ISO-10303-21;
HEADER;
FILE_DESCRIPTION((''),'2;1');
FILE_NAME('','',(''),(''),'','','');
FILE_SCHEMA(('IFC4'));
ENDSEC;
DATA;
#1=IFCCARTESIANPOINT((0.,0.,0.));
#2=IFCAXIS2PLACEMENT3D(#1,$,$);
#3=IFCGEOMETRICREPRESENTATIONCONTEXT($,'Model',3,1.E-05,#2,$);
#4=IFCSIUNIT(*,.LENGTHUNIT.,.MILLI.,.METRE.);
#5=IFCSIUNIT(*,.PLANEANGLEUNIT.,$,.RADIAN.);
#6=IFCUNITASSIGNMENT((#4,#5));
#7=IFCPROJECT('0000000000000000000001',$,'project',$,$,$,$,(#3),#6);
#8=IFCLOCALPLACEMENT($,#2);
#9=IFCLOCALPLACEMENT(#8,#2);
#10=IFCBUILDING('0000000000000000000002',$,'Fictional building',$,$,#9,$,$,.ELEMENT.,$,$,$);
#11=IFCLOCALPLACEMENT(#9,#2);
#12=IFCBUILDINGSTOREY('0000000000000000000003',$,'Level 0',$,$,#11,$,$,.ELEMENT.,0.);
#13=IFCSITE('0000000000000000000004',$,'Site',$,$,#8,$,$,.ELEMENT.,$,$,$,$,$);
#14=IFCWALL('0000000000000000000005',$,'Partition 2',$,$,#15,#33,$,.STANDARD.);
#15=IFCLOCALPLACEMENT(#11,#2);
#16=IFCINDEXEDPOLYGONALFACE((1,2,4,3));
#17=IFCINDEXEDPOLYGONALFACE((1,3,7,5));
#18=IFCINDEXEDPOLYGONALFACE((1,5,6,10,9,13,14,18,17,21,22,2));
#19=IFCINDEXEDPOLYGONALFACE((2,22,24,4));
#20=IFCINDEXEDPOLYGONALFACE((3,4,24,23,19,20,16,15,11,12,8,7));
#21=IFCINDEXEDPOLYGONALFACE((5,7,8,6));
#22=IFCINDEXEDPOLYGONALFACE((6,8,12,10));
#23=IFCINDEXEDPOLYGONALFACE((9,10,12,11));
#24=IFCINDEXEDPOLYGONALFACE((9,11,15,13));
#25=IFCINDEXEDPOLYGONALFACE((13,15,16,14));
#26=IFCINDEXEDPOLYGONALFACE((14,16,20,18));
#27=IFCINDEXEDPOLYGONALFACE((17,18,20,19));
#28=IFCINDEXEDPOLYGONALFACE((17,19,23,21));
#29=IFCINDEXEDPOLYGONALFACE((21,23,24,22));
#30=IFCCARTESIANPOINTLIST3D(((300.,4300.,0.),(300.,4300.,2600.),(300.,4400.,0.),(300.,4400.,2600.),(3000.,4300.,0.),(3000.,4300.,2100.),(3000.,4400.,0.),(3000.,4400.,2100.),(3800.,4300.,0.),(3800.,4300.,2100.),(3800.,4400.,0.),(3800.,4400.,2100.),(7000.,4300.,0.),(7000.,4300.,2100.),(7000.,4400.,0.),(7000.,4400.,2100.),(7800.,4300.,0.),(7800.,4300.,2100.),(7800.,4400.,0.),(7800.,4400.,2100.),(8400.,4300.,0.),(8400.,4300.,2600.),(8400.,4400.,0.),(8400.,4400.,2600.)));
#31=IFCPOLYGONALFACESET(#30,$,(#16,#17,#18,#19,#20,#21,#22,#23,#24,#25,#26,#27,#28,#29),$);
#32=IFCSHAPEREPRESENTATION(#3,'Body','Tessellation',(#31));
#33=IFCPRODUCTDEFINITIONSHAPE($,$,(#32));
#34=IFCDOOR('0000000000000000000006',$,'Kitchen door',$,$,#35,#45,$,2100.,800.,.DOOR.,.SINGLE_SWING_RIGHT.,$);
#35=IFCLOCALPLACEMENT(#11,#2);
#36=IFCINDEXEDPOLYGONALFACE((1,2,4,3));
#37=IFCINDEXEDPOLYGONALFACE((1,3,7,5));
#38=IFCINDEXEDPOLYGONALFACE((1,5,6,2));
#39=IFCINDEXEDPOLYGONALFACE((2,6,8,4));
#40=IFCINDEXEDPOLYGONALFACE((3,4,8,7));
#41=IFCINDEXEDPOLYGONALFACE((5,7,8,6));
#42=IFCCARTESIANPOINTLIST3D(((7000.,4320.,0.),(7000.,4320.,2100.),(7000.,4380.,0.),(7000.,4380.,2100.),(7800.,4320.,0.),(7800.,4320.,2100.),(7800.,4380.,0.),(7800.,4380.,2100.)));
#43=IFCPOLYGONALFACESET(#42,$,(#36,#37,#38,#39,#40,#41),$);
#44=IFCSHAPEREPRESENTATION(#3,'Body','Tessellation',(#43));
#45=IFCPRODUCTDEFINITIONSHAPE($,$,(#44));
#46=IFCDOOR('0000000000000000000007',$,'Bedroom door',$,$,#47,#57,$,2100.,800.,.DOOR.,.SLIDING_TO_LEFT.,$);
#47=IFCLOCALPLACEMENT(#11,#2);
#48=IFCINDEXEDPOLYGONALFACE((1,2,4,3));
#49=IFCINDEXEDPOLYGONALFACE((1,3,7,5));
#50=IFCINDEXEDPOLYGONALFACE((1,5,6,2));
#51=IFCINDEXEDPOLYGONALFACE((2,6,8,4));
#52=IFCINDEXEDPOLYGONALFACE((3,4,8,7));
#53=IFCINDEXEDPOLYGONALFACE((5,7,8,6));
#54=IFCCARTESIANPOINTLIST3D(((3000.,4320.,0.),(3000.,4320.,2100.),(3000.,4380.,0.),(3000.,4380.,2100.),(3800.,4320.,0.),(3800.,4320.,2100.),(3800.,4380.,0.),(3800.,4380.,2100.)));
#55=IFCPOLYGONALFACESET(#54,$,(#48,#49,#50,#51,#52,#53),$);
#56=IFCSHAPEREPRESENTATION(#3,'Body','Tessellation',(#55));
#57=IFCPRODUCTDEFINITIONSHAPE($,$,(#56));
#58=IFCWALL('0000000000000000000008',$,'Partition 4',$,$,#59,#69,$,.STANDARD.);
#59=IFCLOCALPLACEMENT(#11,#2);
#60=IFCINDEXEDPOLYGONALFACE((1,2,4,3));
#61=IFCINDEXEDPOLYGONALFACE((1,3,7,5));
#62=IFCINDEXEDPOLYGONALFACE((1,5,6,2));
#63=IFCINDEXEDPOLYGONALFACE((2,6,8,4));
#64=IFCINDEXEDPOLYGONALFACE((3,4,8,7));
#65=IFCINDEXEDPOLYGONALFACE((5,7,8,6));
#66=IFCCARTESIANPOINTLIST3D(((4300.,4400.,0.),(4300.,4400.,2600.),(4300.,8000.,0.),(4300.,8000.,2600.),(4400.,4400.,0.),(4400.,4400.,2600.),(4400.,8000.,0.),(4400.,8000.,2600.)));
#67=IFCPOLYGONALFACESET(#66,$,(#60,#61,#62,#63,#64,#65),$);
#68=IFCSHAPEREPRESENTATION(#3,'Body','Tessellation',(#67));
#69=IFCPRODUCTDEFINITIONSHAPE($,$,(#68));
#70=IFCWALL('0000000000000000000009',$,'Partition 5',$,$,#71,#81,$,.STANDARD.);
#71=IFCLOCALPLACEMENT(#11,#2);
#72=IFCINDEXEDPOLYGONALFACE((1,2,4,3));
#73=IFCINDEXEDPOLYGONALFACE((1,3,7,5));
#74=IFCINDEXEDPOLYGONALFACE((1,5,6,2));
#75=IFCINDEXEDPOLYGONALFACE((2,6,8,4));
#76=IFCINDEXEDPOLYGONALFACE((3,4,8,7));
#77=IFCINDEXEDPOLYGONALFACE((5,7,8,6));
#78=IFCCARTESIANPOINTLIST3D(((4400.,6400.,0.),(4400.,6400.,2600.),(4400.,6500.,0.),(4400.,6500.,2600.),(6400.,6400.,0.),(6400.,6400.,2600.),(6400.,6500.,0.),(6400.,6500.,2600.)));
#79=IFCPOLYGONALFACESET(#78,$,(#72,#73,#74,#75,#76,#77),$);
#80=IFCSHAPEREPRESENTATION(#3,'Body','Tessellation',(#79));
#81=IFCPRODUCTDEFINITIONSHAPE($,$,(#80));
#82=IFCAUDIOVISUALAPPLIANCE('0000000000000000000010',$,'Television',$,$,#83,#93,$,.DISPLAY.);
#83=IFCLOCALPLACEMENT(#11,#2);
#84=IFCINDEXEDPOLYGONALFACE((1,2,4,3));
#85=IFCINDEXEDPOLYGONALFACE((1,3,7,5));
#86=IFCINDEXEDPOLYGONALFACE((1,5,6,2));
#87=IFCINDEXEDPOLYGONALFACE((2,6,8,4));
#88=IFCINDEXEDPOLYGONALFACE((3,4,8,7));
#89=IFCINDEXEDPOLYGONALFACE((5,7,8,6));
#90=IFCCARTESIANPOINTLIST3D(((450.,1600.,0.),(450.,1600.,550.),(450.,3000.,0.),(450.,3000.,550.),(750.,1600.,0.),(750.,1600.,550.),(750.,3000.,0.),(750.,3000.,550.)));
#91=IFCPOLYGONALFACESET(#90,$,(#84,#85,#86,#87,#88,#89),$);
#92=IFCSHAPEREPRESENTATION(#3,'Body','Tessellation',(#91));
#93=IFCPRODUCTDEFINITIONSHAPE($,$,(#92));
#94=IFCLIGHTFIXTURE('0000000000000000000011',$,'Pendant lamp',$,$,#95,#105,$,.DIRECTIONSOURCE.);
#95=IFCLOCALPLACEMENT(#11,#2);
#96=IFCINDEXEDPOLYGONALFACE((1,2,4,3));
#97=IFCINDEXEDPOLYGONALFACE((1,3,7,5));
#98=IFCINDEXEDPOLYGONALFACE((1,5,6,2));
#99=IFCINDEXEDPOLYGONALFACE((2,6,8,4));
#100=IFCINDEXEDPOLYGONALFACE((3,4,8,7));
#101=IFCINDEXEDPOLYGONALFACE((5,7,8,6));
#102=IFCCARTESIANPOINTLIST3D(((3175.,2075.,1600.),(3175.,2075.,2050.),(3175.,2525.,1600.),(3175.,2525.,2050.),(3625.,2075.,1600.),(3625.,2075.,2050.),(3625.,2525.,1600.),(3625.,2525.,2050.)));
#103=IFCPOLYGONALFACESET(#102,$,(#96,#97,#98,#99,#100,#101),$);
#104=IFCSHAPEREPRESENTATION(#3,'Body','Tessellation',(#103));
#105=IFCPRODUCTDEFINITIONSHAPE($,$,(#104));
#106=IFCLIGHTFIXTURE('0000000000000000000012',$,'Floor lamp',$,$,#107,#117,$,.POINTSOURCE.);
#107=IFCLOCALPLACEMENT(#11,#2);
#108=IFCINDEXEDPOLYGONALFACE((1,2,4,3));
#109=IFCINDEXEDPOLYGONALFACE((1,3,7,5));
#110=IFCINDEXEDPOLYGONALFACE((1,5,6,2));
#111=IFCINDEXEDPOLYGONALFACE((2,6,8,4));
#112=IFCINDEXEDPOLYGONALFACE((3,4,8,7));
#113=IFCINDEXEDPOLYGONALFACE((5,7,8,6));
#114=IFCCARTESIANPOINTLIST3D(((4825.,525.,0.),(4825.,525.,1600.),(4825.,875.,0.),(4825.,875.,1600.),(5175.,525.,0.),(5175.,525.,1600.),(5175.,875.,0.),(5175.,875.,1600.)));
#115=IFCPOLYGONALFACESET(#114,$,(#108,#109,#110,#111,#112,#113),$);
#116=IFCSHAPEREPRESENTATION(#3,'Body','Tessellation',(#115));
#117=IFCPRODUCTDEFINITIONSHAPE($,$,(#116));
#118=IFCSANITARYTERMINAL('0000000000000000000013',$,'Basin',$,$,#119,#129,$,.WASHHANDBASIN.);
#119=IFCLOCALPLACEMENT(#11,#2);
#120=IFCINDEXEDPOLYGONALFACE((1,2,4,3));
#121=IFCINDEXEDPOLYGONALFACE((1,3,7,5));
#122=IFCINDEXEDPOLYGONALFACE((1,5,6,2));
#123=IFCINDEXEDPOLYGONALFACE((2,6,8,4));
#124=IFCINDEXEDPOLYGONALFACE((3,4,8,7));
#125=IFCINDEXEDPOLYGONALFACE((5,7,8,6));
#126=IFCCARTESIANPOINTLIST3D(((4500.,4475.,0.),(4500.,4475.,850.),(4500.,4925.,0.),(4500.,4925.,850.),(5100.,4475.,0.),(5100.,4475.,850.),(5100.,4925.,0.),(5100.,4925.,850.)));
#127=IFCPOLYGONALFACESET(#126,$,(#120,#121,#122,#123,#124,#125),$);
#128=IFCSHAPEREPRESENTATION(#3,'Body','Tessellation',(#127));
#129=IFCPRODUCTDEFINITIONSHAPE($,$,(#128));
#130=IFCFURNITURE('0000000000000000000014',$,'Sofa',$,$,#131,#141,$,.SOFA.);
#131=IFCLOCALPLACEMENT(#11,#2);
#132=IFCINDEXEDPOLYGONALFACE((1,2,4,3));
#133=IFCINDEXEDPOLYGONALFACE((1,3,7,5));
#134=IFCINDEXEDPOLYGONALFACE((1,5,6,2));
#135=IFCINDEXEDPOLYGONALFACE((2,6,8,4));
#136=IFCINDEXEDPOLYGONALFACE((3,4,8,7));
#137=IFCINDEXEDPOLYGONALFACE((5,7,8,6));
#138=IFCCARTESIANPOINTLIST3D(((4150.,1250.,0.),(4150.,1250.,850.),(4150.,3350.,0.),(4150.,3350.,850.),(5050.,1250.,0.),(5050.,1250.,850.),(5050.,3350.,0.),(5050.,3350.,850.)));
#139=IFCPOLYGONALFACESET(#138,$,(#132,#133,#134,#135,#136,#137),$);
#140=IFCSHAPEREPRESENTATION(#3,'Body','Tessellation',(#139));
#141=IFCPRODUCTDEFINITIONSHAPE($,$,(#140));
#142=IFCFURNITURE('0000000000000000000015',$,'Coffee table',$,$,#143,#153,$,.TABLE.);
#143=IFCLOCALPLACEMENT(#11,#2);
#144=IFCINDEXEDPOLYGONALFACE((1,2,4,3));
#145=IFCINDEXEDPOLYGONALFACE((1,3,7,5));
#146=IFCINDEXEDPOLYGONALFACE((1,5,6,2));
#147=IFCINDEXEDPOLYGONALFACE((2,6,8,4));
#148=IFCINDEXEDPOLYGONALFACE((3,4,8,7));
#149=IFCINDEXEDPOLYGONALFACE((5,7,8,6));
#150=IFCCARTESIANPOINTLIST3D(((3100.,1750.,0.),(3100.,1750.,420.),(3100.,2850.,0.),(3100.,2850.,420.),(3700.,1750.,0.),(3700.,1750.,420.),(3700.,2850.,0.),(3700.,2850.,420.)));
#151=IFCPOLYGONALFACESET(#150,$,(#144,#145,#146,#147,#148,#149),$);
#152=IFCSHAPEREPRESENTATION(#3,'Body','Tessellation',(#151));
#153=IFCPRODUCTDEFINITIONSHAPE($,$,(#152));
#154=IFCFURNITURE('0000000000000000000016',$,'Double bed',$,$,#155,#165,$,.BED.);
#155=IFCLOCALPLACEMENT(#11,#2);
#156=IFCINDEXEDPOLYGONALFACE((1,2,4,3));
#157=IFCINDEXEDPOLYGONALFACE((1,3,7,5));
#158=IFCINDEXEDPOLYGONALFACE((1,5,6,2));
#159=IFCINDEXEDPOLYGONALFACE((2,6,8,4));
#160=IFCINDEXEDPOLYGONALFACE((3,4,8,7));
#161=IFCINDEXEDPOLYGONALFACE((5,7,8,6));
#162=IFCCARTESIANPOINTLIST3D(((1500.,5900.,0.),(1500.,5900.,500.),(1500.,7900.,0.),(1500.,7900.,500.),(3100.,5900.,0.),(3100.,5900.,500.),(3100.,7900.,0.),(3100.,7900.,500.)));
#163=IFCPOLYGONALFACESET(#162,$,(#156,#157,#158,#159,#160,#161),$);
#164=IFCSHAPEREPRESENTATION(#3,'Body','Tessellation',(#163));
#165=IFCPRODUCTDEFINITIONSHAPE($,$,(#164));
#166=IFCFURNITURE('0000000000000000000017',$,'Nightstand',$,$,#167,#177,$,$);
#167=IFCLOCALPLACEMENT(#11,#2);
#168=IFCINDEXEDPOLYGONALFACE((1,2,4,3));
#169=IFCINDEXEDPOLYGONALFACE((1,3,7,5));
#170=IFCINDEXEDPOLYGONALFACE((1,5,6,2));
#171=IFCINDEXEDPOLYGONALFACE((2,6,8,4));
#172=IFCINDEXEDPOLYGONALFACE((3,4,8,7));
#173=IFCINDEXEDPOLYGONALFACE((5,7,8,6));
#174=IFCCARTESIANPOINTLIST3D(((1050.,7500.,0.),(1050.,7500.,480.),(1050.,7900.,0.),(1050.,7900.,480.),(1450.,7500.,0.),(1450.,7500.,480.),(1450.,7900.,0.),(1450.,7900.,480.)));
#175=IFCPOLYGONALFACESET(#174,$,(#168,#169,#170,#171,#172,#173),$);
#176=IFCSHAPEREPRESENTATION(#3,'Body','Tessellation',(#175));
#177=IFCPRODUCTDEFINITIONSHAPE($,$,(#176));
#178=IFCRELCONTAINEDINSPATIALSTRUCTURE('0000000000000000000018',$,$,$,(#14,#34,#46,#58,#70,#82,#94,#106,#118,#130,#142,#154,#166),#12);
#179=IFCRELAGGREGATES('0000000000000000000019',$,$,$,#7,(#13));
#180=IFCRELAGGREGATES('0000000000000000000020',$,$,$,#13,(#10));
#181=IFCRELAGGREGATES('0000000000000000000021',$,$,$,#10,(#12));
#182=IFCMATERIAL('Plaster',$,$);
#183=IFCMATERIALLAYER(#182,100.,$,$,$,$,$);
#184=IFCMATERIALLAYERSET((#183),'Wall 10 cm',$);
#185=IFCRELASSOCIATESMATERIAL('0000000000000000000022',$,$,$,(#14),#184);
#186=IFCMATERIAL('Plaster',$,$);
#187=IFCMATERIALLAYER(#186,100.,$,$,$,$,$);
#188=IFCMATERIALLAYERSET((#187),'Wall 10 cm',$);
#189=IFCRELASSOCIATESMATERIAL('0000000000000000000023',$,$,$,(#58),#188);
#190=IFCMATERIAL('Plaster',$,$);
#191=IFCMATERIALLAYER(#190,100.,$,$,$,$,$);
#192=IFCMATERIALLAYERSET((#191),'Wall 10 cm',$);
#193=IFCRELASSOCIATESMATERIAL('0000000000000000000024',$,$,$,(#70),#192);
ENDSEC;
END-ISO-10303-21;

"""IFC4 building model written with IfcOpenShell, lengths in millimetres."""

from ifc_helpers import new_model, si_unit, frame, frame_2d, origin, origin_2d, place, context, project, spatial, rectangle, extrude, source, transform, mapped, material, layer, layer_set, layer_usage, element, fill, save


model = new_model("IFC4")

# Units and contexts
model_context = context("Model", 3, precision=1e-05, world=origin())
ifc_project = project(units=[si_unit("LENGTHUNIT", "METRE", prefix="MILLI"), si_unit("PLANEANGLEUNIT", "RADIAN")], contexts=[model_context])

# Site, building, storey
site_placement = place(None, origin())
site = spatial("IfcSite", under=ifc_project, at=site_placement, Name="Site", CompositionType="ELEMENT")
building_placement = place(site_placement, origin())
building = spatial("IfcBuilding", under=site, at=building_placement, Name="Fictional building", CompositionType="ELEMENT")
storey_placement = place(building_placement, origin())
storey = spatial("IfcBuildingStorey", under=building, at=storey_placement, Name="Level 0", CompositionType="ELEMENT", Elevation=0.0)

# Wall, openings, doors
ifc_material_1 = material(Name="Plaster")
ifc_layer_1 = layer(ifc_material_1, 100.0)
ifc_layer_set_1 = layer_set([ifc_layer_1], Name="Wall 10 cm")
ifc_layer_usage_1 = layer_usage(ifc_layer_set_1, "AXIS2", "POSITIVE", -50.0)
wall_1_placement = place(storey_placement, frame((300.0, 4350.0, 0.0)))
wall_1 = element("IfcWall", 1, at=wall_1_placement, inside=storey, material=ifc_layer_usage_1, Name="Partition 2", PredefinedType="STANDARD", context=model_context, shape_type="SweptSolid", body=[
    extrude(rectangle(XDim=8100.0, YDim=100.0, at=frame_2d((4050.0, 0.0))), origin(), (0.0, 0.0, 1.0), 2600.0),
])
opening_1_placement = place(storey_placement, frame((7000.0, 4350.0, 0.0)))
opening_1 = element("IfcOpeningElement", 2, at=opening_1_placement, cuts=wall_1, PredefinedType="OPENING", context=model_context, shape_type="SweptSolid", body=[
    extrude(rectangle(XDim=800.0, YDim=200.0, at=frame_2d((400.0, 0.0))), origin(), (0.0, 0.0, 1.0), 2100.0),
])
opening_2_placement = place(storey_placement, frame((3000.0, 4350.0, 0.0)))
opening_2 = element("IfcOpeningElement", 3, at=opening_2_placement, cuts=wall_1, PredefinedType="OPENING", context=model_context, shape_type="SweptSolid", body=[
    extrude(rectangle(XDim=800.0, YDim=200.0, at=frame_2d((400.0, 0.0))), origin(), (0.0, 0.0, 1.0), 2100.0),
])
door_1_placement = place(opening_1_placement, origin())
door_1 = element("IfcDoor", 4, at=door_1_placement, inside=storey, Name="Kitchen door", OperationType="SINGLE_SWING_RIGHT", OverallHeight=2100.0, OverallWidth=800.0, PredefinedType="DOOR", context=model_context, shape_type="SweptSolid", body=[
    extrude(rectangle(XDim=800.0, YDim=60.0, at=frame_2d((400.0, 0.0))), origin(), (0.0, 0.0, 1.0), 2100.0),
])
fill(opening_1, door_1)
door_2_placement = place(opening_2_placement, origin())
door_2 = element("IfcDoor", 5, at=door_2_placement, inside=storey, Name="Bedroom door", OperationType="SLIDING_TO_LEFT", OverallHeight=2100.0, OverallWidth=800.0, PredefinedType="DOOR", context=model_context, shape_type="SweptSolid", body=[
    extrude(rectangle(XDim=800.0, YDim=60.0, at=frame_2d((400.0, 0.0))), origin(), (0.0, 0.0, 1.0), 2100.0),
])
fill(opening_2, door_2)

# Walls
ifc_material_2 = material(Name="Plaster")
ifc_layer_2 = layer(ifc_material_2, 100.0)
ifc_layer_set_2 = layer_set([ifc_layer_2], Name="Wall 10 cm")
ifc_layer_usage_2 = layer_usage(ifc_layer_set_2, "AXIS2", "POSITIVE", -50.0)
wall_2_placement = place(storey_placement, frame((4350.0, 4400.0, 0.0), z_axis=(0.0, 0.0, 1.0), x_axis=(0.0, 1.0, 0.0)))
element("IfcWall", 6, at=wall_2_placement, inside=storey, material=ifc_layer_usage_2, Name="Partition 4", PredefinedType="STANDARD", context=model_context, shape_type="SweptSolid", body=[
    extrude(rectangle(XDim=3600.0, YDim=100.0, at=frame_2d((1800.0, 0.0))), origin(), (0.0, 0.0, 1.0), 2600.0),
])
ifc_material_3 = material(Name="Plaster")
ifc_layer_3 = layer(ifc_material_3, 100.0)
ifc_layer_set_3 = layer_set([ifc_layer_3], Name="Wall 10 cm")
ifc_layer_usage_3 = layer_usage(ifc_layer_set_3, "AXIS2", "POSITIVE", -50.0)
wall_3_placement = place(storey_placement, frame((4400.0, 6450.0, 0.0)))
element("IfcWall", 7, at=wall_3_placement, inside=storey, material=ifc_layer_usage_3, Name="Partition 5", PredefinedType="STANDARD", context=model_context, shape_type="SweptSolid", body=[
    extrude(rectangle(XDim=2000.0, YDim=100.0, at=frame_2d((1000.0, 0.0))), origin(), (0.0, 0.0, 1.0), 2600.0),
])

# Audio visual appliance
shared_shape_1 = source(origin(), model_context, "Body", "SweptSolid", [
    extrude(rectangle(XDim=1400.0, YDim=300.0, at=origin_2d()), origin(), (0.0, 0.0, 1.0), 550.0),
])
audio_visual_appliance_placement = place(storey_placement, frame((600.0, 2300.0, 0.0), z_axis=(0.0, 0.0, 1.0), x_axis=(0.0, -1.0, 0.0)))
element("IfcAudioVisualAppliance", 8, at=audio_visual_appliance_placement, inside=storey, Name="Television", PredefinedType="DISPLAY", context=model_context, shape_type="MappedRepresentation", body=[
    mapped(shared_shape_1, transform((0.0, 0.0, 0.0), scale=1.0)),
])

# Light fixtures
shared_shape_2 = source(origin(), model_context, "Body", "SweptSolid", [
    extrude(rectangle(XDim=450.0, YDim=450.0, at=origin_2d()), origin(), (0.0, 0.0, 1.0), 450.0),
])
light_fixture_1_placement = place(storey_placement, frame((3400.0, 2300.0, 1600.0)))
element("IfcLightFixture", 9, at=light_fixture_1_placement, inside=storey, Name="Pendant lamp", PredefinedType="DIRECTIONSOURCE", context=model_context, shape_type="MappedRepresentation", body=[
    mapped(shared_shape_2, transform((0.0, 0.0, 0.0), scale=1.0)),
])
shared_shape_3 = source(origin(), model_context, "Body", "SweptSolid", [
    extrude(rectangle(XDim=350.0, YDim=350.0, at=origin_2d()), origin(), (0.0, 0.0, 1.0), 1600.0),
])
light_fixture_2_placement = place(storey_placement, frame((5000.0, 700.0, 0.0)))
element("IfcLightFixture", 10, at=light_fixture_2_placement, inside=storey, Name="Floor lamp", PredefinedType="POINTSOURCE", context=model_context, shape_type="MappedRepresentation", body=[
    mapped(shared_shape_3, transform((0.0, 0.0, 0.0), scale=1.0)),
])

# Sanitary terminal
shared_shape_4 = source(origin(), model_context, "Body", "SweptSolid", [
    extrude(rectangle(XDim=600.0, YDim=450.0, at=origin_2d()), origin(), (0.0, 0.0, 1.0), 850.0),
])
sanitary_terminal_placement = place(storey_placement, frame((4800.0, 4700.0, 0.0)))
element("IfcSanitaryTerminal", 11, at=sanitary_terminal_placement, inside=storey, Name="Basin", PredefinedType="WASHHANDBASIN", context=model_context, shape_type="MappedRepresentation", body=[
    mapped(shared_shape_4, transform((0.0, 0.0, 0.0), scale=1.0)),
])

# Furniture
shared_shape_5 = source(origin(), model_context, "Body", "SweptSolid", [
    extrude(rectangle(XDim=2100.0, YDim=900.0, at=origin_2d()), origin(), (0.0, 0.0, 1.0), 850.0),
])
furniture_1_placement = place(storey_placement, frame((4600.0, 2300.0, 0.0), z_axis=(0.0, 0.0, 1.0), x_axis=(0.0, 1.0, 0.0)))
element("IfcFurniture", 12, at=furniture_1_placement, inside=storey, Name="Sofa", PredefinedType="SOFA", context=model_context, shape_type="MappedRepresentation", body=[
    mapped(shared_shape_5, transform((0.0, 0.0, 0.0), scale=1.0)),
])
shared_shape_6 = source(origin(), model_context, "Body", "SweptSolid", [
    extrude(rectangle(XDim=1100.0, YDim=600.0, at=origin_2d()), origin(), (0.0, 0.0, 1.0), 420.0),
])
furniture_2_placement = place(storey_placement, frame((3400.0, 2300.0, 0.0), z_axis=(0.0, 0.0, 1.0), x_axis=(0.0, 1.0, 0.0)))
element("IfcFurniture", 13, at=furniture_2_placement, inside=storey, Name="Coffee table", PredefinedType="TABLE", context=model_context, shape_type="MappedRepresentation", body=[
    mapped(shared_shape_6, transform((0.0, 0.0, 0.0), scale=1.0)),
])
shared_shape_7 = source(origin(), model_context, "Body", "SweptSolid", [
    extrude(rectangle(XDim=1600.0, YDim=2000.0, at=origin_2d()), origin(), (0.0, 0.0, 1.0), 500.0),
])
furniture_3_placement = place(storey_placement, frame((2300.0, 6900.0, 0.0)))
element("IfcFurniture", 14, at=furniture_3_placement, inside=storey, Name="Double bed", PredefinedType="BED", context=model_context, shape_type="MappedRepresentation", body=[
    mapped(shared_shape_7, transform((0.0, 0.0, 0.0), scale=1.0)),
])
shared_shape_8 = source(origin(), model_context, "Body", "SweptSolid", [
    extrude(rectangle(XDim=400.0, YDim=400.0, at=origin_2d()), origin(), (0.0, 0.0, 1.0), 480.0),
])
for number, where, name in (
    (15, (1250.0, 7700.0, 0.0), "Nightstand"),
):
    element("IfcFurniture", number, at=place(storey_placement, frame(where)), inside=storey, Name=name, context=model_context, shape_type="MappedRepresentation", body=[
        mapped(shared_shape_8, transform((0.0, 0.0, 0.0), scale=1.0)),
    ])

save(model, "model.ifc")
